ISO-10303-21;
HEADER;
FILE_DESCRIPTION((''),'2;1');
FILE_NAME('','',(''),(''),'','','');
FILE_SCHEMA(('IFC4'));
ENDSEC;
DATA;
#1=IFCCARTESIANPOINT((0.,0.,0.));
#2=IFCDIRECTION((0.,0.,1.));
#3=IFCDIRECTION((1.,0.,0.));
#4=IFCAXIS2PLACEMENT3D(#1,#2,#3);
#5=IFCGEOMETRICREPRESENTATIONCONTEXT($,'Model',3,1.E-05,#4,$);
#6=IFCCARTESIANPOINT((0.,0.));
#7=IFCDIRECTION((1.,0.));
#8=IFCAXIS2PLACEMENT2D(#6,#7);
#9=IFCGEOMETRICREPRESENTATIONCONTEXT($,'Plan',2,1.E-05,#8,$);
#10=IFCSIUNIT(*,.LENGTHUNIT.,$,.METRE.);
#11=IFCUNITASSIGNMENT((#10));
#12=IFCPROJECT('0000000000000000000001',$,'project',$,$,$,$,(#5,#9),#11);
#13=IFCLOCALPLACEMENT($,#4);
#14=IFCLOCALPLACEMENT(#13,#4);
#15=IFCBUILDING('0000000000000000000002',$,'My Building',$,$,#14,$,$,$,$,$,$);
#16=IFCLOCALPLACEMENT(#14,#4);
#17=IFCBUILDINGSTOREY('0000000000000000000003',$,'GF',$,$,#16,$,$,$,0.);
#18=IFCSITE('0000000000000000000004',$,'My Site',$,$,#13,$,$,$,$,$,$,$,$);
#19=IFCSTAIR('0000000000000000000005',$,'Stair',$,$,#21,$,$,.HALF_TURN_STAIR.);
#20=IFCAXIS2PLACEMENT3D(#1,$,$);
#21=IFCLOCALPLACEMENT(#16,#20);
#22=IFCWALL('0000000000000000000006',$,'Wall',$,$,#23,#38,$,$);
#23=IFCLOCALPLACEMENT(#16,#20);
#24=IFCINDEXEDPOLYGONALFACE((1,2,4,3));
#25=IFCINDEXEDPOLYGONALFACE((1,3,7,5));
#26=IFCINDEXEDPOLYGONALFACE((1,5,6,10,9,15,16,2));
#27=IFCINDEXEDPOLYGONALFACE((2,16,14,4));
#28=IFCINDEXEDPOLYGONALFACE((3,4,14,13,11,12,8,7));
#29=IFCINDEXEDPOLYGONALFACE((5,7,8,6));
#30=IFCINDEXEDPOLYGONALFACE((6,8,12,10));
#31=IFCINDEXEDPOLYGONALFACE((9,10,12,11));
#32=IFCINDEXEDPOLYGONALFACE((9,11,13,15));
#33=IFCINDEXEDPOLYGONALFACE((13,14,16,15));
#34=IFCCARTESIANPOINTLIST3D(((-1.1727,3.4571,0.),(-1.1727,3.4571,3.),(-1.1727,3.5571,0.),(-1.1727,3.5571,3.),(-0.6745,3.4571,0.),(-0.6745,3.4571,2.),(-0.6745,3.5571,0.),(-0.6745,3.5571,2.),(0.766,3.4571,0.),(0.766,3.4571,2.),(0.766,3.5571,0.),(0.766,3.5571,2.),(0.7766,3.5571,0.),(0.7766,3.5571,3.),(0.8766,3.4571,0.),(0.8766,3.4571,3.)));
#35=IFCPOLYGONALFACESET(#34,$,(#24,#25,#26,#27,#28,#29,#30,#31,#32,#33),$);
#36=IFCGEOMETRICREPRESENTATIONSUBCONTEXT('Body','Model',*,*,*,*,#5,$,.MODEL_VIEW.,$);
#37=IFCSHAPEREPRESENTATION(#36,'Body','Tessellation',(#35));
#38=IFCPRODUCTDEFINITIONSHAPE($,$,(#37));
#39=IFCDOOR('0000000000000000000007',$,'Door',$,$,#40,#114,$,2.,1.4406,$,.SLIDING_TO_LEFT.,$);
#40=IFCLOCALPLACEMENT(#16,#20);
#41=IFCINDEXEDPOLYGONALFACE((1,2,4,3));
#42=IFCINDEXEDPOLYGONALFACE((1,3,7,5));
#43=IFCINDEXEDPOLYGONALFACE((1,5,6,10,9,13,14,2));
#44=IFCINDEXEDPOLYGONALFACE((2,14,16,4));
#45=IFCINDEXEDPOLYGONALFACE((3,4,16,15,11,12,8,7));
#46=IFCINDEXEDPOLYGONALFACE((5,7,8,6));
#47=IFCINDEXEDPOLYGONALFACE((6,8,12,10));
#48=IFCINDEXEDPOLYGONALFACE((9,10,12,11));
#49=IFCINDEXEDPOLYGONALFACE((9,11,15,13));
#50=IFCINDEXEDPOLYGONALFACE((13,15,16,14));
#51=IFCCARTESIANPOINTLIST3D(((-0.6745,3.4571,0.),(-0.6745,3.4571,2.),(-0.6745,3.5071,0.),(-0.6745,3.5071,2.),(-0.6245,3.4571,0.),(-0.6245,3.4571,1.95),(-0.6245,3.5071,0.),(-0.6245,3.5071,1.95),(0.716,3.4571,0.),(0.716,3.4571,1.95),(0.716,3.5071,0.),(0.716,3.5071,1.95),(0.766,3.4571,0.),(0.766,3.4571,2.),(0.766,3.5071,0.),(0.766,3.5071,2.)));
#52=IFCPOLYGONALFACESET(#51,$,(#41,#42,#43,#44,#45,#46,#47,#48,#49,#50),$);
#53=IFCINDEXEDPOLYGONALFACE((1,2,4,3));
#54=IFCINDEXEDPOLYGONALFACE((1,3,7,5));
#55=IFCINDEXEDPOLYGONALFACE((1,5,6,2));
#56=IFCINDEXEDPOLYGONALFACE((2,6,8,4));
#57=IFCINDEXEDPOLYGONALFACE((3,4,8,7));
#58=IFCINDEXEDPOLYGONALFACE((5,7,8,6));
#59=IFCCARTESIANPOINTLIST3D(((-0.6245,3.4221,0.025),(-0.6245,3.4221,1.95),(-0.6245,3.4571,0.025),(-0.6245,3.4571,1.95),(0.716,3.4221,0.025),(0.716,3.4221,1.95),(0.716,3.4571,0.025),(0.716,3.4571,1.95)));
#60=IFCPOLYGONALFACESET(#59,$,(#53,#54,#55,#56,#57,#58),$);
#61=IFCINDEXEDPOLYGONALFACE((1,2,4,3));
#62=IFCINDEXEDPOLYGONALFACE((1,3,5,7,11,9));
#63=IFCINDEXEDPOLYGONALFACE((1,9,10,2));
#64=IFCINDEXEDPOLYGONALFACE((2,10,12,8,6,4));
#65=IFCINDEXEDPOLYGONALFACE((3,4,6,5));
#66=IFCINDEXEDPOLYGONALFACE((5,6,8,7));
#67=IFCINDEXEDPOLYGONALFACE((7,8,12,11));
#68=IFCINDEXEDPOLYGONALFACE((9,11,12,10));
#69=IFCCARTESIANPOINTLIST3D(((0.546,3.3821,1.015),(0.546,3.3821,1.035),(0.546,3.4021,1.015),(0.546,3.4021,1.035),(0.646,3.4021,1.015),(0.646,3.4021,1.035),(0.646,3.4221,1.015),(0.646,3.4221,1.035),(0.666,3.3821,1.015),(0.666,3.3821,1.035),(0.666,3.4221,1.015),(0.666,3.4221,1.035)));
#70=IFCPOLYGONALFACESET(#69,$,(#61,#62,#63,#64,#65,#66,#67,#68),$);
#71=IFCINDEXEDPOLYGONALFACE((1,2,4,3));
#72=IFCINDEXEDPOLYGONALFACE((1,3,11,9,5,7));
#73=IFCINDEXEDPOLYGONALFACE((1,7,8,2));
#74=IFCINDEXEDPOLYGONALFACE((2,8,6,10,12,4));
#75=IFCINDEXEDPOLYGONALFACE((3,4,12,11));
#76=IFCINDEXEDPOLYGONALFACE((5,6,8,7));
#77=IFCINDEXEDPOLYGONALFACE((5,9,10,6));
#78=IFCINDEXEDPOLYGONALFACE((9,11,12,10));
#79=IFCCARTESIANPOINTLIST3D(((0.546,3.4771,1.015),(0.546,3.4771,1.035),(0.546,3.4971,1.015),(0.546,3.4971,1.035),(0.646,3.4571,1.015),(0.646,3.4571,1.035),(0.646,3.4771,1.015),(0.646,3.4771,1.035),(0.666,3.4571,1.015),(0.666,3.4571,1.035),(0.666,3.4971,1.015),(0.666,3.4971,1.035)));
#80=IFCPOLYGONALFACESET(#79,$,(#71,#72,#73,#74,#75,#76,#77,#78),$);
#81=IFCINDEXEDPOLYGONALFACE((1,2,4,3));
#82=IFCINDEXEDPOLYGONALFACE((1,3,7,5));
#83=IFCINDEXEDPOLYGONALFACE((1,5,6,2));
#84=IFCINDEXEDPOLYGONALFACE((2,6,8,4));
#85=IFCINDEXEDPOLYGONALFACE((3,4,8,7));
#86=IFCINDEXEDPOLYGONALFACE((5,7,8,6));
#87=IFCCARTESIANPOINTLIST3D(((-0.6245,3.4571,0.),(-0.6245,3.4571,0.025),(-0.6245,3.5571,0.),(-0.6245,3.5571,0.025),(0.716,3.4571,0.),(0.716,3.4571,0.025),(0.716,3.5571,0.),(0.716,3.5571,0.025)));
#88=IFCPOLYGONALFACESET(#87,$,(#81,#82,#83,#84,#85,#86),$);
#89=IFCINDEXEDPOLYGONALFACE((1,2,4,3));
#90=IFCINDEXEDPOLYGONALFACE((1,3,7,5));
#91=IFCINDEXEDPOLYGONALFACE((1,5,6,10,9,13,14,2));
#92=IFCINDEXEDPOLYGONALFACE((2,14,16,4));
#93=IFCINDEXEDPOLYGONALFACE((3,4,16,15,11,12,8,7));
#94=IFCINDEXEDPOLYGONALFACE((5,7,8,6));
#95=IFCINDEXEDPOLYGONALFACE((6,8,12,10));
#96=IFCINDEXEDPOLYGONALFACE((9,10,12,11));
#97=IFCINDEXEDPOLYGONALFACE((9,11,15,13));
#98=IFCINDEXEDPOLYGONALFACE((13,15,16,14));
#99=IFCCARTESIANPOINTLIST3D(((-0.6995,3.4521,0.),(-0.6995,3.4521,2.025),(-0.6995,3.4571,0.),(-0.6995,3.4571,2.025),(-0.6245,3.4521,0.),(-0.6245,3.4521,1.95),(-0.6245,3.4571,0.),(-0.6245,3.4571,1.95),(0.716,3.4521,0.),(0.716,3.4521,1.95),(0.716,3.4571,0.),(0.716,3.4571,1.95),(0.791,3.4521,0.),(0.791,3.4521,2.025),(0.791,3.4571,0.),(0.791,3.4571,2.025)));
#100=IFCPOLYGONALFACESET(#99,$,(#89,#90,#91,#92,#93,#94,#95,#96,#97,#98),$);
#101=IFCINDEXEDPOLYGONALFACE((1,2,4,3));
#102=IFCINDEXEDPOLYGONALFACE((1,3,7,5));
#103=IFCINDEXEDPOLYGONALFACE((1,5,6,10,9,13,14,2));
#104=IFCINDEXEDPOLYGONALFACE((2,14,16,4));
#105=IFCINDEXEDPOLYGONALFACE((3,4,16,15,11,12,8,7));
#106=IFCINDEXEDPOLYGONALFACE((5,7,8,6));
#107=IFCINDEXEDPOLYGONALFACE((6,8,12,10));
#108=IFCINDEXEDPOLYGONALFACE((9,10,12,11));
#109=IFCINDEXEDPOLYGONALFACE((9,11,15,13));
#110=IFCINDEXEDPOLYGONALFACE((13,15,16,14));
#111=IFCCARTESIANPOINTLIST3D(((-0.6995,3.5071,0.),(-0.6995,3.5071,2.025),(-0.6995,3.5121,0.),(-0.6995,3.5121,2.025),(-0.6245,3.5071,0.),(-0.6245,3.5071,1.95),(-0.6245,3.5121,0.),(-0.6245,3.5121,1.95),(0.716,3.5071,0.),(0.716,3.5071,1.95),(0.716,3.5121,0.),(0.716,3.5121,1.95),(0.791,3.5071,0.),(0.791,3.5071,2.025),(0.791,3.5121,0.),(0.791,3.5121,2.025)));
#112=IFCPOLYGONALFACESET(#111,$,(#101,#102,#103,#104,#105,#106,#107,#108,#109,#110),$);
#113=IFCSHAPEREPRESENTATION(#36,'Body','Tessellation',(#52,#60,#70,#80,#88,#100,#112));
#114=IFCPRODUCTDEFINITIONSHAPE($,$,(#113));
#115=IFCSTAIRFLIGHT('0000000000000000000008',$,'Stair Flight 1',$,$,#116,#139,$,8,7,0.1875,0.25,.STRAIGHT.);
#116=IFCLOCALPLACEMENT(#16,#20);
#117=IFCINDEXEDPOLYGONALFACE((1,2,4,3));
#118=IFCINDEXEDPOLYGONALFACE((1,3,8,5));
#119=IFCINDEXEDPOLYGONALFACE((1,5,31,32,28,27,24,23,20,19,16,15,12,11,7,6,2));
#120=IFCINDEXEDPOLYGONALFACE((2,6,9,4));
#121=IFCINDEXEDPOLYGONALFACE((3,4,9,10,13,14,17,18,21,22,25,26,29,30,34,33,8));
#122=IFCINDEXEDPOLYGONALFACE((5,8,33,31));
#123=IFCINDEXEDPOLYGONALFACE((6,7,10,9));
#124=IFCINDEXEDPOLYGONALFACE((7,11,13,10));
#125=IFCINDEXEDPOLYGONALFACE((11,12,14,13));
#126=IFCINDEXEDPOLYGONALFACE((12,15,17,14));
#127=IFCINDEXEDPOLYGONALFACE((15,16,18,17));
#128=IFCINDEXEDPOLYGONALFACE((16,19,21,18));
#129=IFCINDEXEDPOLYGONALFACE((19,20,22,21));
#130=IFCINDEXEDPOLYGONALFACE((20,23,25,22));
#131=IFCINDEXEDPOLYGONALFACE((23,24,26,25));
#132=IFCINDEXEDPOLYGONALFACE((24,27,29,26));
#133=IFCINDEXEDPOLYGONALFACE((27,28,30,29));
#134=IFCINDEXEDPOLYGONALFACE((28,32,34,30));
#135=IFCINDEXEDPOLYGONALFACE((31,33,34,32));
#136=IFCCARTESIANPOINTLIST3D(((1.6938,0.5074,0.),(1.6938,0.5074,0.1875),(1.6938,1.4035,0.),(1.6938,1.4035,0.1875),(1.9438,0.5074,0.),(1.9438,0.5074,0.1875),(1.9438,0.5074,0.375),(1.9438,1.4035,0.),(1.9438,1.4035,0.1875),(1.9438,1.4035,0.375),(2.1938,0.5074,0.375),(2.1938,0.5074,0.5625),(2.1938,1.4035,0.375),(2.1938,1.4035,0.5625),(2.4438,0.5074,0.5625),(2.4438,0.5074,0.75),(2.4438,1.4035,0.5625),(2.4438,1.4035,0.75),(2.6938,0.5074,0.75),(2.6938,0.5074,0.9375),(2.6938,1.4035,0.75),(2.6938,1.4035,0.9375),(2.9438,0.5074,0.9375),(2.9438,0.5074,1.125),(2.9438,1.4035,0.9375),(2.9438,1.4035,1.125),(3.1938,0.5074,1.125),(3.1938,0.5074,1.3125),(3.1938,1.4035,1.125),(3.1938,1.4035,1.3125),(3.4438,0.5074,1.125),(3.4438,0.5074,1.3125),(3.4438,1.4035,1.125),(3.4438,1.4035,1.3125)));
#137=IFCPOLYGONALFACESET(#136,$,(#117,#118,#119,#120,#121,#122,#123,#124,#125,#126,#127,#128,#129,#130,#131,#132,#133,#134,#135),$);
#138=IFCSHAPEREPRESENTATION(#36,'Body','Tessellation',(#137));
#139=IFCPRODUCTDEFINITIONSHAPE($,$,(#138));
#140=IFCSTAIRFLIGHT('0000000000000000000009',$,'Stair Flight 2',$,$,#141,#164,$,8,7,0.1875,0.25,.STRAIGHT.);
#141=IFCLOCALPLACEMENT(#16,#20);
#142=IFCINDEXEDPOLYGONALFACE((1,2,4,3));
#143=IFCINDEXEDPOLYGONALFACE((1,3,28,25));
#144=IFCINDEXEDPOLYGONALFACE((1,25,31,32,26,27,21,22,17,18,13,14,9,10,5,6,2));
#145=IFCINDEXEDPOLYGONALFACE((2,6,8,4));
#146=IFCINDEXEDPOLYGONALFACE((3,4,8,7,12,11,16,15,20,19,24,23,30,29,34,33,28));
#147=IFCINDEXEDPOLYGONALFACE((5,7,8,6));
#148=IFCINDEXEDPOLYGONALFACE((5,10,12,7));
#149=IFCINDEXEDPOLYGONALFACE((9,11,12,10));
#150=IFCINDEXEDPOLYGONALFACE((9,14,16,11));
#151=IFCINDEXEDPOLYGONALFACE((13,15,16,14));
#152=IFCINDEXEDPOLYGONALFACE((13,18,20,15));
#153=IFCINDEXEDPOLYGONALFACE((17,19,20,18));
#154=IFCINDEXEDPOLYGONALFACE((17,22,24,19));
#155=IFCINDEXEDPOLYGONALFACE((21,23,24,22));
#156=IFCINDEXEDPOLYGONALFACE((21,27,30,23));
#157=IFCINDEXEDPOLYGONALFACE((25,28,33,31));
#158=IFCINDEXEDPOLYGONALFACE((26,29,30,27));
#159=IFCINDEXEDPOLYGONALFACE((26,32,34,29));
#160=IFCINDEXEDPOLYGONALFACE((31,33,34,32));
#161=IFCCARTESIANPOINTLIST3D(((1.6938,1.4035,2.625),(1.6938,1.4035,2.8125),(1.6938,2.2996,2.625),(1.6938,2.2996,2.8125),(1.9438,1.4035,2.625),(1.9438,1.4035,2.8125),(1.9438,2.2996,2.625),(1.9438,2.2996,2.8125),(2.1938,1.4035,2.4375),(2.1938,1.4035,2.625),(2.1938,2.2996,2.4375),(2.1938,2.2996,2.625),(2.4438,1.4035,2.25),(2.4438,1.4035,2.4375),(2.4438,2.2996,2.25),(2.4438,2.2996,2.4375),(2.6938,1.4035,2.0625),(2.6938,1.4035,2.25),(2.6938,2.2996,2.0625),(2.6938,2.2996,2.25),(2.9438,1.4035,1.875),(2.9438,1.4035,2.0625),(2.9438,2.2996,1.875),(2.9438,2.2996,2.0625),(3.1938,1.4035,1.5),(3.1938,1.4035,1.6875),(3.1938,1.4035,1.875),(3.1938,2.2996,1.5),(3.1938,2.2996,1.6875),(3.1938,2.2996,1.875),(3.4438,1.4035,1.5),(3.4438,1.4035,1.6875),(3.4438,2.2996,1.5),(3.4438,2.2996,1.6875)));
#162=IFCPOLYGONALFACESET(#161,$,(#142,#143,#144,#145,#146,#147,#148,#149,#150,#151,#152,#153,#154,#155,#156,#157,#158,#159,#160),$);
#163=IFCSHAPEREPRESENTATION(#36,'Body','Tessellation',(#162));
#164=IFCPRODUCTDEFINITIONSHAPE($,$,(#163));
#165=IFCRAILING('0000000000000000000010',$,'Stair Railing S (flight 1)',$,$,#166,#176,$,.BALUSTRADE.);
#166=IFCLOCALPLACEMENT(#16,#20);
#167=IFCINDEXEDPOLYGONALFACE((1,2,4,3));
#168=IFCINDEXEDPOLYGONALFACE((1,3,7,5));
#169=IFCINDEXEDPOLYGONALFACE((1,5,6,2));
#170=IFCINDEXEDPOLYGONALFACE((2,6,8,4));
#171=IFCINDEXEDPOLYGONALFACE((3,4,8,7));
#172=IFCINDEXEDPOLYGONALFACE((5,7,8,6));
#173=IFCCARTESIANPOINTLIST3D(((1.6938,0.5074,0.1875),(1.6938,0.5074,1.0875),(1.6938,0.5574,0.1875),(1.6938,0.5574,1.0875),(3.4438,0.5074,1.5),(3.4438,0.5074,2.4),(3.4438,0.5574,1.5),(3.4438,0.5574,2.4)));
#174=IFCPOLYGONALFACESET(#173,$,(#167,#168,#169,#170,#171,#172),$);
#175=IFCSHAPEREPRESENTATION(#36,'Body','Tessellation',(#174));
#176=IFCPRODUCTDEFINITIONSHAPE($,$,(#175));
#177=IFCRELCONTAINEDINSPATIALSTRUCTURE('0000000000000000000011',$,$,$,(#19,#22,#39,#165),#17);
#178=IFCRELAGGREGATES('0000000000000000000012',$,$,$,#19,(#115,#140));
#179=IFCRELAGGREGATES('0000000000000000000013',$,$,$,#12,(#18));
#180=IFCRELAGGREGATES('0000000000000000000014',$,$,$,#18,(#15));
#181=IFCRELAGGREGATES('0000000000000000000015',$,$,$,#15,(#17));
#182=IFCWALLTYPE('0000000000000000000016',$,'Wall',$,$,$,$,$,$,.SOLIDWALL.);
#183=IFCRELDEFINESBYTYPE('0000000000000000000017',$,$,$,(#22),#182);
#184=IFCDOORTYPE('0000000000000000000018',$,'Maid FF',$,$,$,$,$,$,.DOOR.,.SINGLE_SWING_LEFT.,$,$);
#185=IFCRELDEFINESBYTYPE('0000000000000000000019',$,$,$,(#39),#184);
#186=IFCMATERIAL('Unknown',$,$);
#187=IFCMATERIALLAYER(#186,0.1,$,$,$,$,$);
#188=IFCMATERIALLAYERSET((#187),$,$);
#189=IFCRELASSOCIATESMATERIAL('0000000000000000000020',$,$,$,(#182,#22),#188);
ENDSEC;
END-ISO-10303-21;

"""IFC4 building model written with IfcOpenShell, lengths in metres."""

from ifc_helpers import new_model, entity, si_unit, frame, origin_with_axes, origin_2d_with_axis, place, context, subcontext, project, spatial, polyline, line, indexed_curve, outline, extrude, shape, source, transform, mapped, material, layer, layer_set, layer_usage, type_object, type_shapes, element, fill, aggregate, save


model = new_model("IFC4")

# Units and contexts
model_context = context("Model", 3, precision=1e-05, world=origin_with_axes())
plan_context = context("Plan", 2, precision=1e-05, world=origin_2d_with_axis())
body_context_1 = subcontext(model_context, "Body", "Model", "MODEL_VIEW")
body_context_2 = subcontext(plan_context, "Body", "Plan", "PLAN_VIEW")
ifc_project = project(units=[si_unit("LENGTHUNIT", "METRE")], contexts=[model_context, plan_context])

# Site, building, storey
site_placement = place(None, origin_with_axes())
site = spatial("IfcSite", under=ifc_project, at=site_placement, Name="My Site")
building_placement = place(site_placement, origin_with_axes())
building = spatial("IfcBuilding", under=site, at=building_placement, Name="My Building")
storey_placement = place(building_placement, origin_with_axes())
storey = spatial("IfcBuildingStorey", under=building, at=storey_placement, Name="GF", Elevation=0.0)

# Shared definitions
ifc_material = material(Name="Unknown")

# Stair
stair_placement = place(storey_placement, origin_with_axes())
stair = element("IfcStair", 1, at=stair_placement, inside=storey, Name="Stair", PredefinedType="HALF_TURN_STAIR")

# Shared definitions
ifc_layer_1 = layer(ifc_material, 0.1)
ifc_layer_set_1 = layer_set([ifc_layer_1])
wall_type = type_object("IfcWallType", Name="Wall", PredefinedType="SOLIDWALL", material=ifc_layer_set_1)

# Wall, opening, door
ifc_layer_usage_1 = layer_usage(ifc_layer_set_1, "AXIS2", "POSITIVE", 0.0)
wall_1_placement = place(storey_placement, frame((0.7766, 3.5571, 0.0), z_axis=(0.0, 0.0, 1.0), x_axis=(-1.0, 0.0, 0.0)))
wall_1 = element("IfcWall", 2, at=wall_1_placement, inside=storey, type_object=wall_type, material=ifc_layer_usage_1, Name="Wall", context=body_context_1, shape_type="SweptSolid", body=[
    extrude(outline(indexed_curve([(0.0, 0.0), (-0.1, 0.1), (1.9493, 0.1), (1.9493, 0.0)], segments=[line(1, 2, 3, 4, 1)])), origin_with_axes(), (0.0, 0.0, 1.0), 3.0),
])
shared_shape_1 = source(origin_with_axes(), body_context_1, "Body", "SweptSolid", [
    extrude(outline(indexed_curve([(0.0, 0.0), (1.4406, 0.0), (1.4406, 2.0), (0.0, 2.0)], segments=[line(1, 2, 3, 4, 1)])), frame((0.0, -0.6, 0.0), z_axis=(0.0, -1.0, 0.0), x_axis=(1.0, 0.0, 0.0)), (0.0, 0.0, -1.0), 1.2),
])
opening_1_placement = place(wall_1_placement, frame((1.4511, 0.1, 0.0), z_axis=(0.0, 0.0, 1.0), x_axis=(-1.0, 0.000001, 0.0)))
opening_1 = element("IfcOpeningElement", 3, at=opening_1_placement, cuts=wall_1, PredefinedType="OPENING", context=body_context_1, shape_type="MappedRepresentation", body=[
    mapped(shared_shape_1, transform((0.0, 0.0, 0.0), x_axis=(1.0, 0.0, 0.0), y_axis=(0.0, 1.0, 0.0), z_axis=(0.0, 0.0, 1.0), scale=1.0)),
])
door_type_1 = type_object("IfcDoorType", Name="Maid FF", OperationType="SINGLE_SWING_LEFT", PredefinedType="DOOR")
shared_shape_2 = source(origin_with_axes(), body_context_1, "Body", "SweptSolid", [
    extrude(outline(indexed_curve([(0.0, 0.0), (0.0, 2.0), (1.4406, 2.0), (1.4406, 0.0), (1.3906, 0.0), (1.3906, 1.95), (0.05, 1.95), (0.05, 0.0)], segments=[line(1, 2, 3, 4, 5, 6, 7, 8, 1)])), frame((0.0, 0.0, 0.0), z_axis=(0.0, -1.0, 0.0), x_axis=(1.0, 0.0, 0.0)), (0.0, 0.0, -1.0), 0.05),
    extrude(outline(indexed_curve([(0.0, 0.0), (1.3406, 0.0), (1.3406, 0.035), (0.0, 0.035)], segments=[line(1, 2, 3, 4, 1)])), frame((0.05, -0.035, 0.025), z_axis=(0.0, 0.0, 1.0), x_axis=(1.0, 0.0, 0.0)), (0.0, 0.0, 1.0), 1.925),
    extrude(outline(indexed_curve([(0.0, 0.0), (0.0, -0.04), (-0.12, -0.04), (-0.12, -0.02), (-0.02, -0.02), (-0.02, 0.0)], segments=[line(1, 2, 3, 4, 5, 6, 1)])), frame((1.3406, -0.035, 1.015), z_axis=(0.0, 0.0, 1.0), x_axis=(1.0, 0.0, 0.0)), (0.0, 0.0, 1.0), 0.02),
    extrude(outline(indexed_curve([(0.0, 0.0), (0.0, 0.04), (-0.12, 0.04), (-0.12, 0.02), (-0.02, 0.02), (-0.02, 0.0)], segments=[line(1, 2, 3, 4, 5, 6, 1)])), frame((1.3406, 0.0, 1.015), z_axis=(0.0, 0.0, 1.0), x_axis=(1.0, 0.0, 0.0)), (0.0, 0.0, 1.0), 0.02),
    extrude(outline(indexed_curve([(0.0, 0.0), (1.3406, 0.0), (1.3406, 0.1), (0.0, 0.1)], segments=[line(1, 2, 3, 4, 1)])), frame((0.05, 0.0, 0.0), z_axis=(0.0, 0.0, 1.0), x_axis=(1.0, 0.0, 0.0)), (0.0, 0.0, 1.0), 0.025),
    extrude(outline(indexed_curve([(0.0, 0.0), (0.0, 2.025), (1.4906, 2.025), (1.4906, 0.0), (1.4156, 0.0), (1.4156, 1.95), (0.075, 1.95), (0.075, 0.0)], segments=[line(1, 2, 3, 4, 5, 6, 7, 8, 1)])), frame((-0.025, -0.005, 0.0), z_axis=(0.0, -1.0, 0.0), x_axis=(1.0, 0.0, 0.0)), (0.0, 0.0, -1.0), 0.005),
    extrude(outline(indexed_curve([(0.0, 0.0), (0.0, 2.025), (1.4906, 2.025), (1.4906, 0.0), (1.4156, 0.0), (1.4156, 1.95), (0.075, 1.95), (0.075, 0.0)], segments=[line(1, 2, 3, 4, 5, 6, 7, 8, 1)])), frame((-0.025, 0.05, 0.0), z_axis=(0.0, -1.0, 0.0), x_axis=(1.0, 0.0, 0.0)), (0.0, 0.0, -1.0), 0.005),
])
shared_shape_3 = source(origin_with_axes(), body_context_2, "Body", "Curve2D", [
    entity("IfcIndexedPolyCurve", entity("IfcCartesianPointList2D", [[0.0, 0.0], [0.05, 0.0], [0.05, 0.05], [0.0, 0.05]]), [entity("IfcLineIndex", [1, 2, 3, 4, 1])]),
    entity("IfcIndexedPolyCurve", entity("IfcCartesianPointList2D", [[1.4406, 0.0], [1.3906, 0.0], [1.3906, 0.05], [1.4406, 0.05]]), [entity("IfcLineIndex", [1, 2, 3, 4, 1])]),
    entity("IfcIndexedPolyCurve", entity("IfcCartesianPointList2D", [[-0.6203, -0.035], [0.7203, -0.035], [0.7203, 0.0], [-0.6203, 0.0]]), [entity("IfcLineIndex", [1, 2, 3, 4, 1])]),
])
type_shapes(door_type_1, [shared_shape_2, shared_shape_3])
door_1_placement = place(opening_1_placement, frame((0.0, 0.0, 0.0), z_axis=(0.0, 0.0, 1.0), x_axis=(1.0, 0.0, 0.0)))
door_1 = element("IfcDoor", 4, at=door_1_placement, inside=storey, type_object=door_type_1, Name="Door", OperationType="SLIDING_TO_LEFT", OverallHeight=2.0, OverallWidth=1.4406, shapes=[
    shape(body_context_1, "Body", "MappedRepresentation", [mapped(shared_shape_2, transform((0.0, 0.0, 0.0), x_axis=(1.0, 0.0, 0.0), y_axis=(0.0, 1.0, 0.0), z_axis=(0.0, 0.0, 1.0), scale=1.0))]),
    shape(body_context_2, "Body", "MappedRepresentation", [mapped(shared_shape_3, transform((0.0, 0.0, 0.0), x_axis=(1.0, 0.0, 0.0), y_axis=(0.0, 1.0, 0.0), z_axis=(0.0, 0.0, 1.0), scale=1.0))]),
])
fill(opening_1, door_1)

# Stair flights
stair_flight_1_placement = place(stair_placement, frame((1.6938, 1.4035, 0.0), z_axis=(0.0, -1.0, 0.0), x_axis=(1.0, 0.0, 0.0)))
stair_flight_1 = element("IfcStairFlight", 5, at=stair_flight_1_placement, Name="Stair Flight 1", NumberOfRisers=8, NumberOfTreads=7, PredefinedType="STRAIGHT", RiserHeight=0.1875, TreadLength=0.25, context=body_context_1, shape_type="SweptSolid", body=[
    extrude(outline(polyline([(0.25, 0.0), (0.0, 0.0), (0.0, 0.1875), (0.25, 0.1875), (0.25, 0.375), (0.5, 0.375), (0.5, 0.5625), (0.75, 0.5625), (0.75, 0.75), (1.0, 0.75), (1.0, 0.9375), (1.25, 0.9375), (1.25, 1.125), (1.5, 1.125), (1.5, 1.3125), (1.75, 1.3125), (1.75, 1.5), (1.75, 1.125), (0.25, 0.0)])), origin_with_axes(), (0.0, 0.0, 1.0), 0.8961),
])
stair_flight_2_placement = place(stair_placement, frame((3.4438, 1.4035, 1.5), z_axis=(0.0, 1.0, 0.0), x_axis=(-1.0, 0.0, 0.0)))
stair_flight_2 = element("IfcStairFlight", 6, at=stair_flight_2_placement, Name="Stair Flight 2", NumberOfRisers=8, NumberOfTreads=7, PredefinedType="STRAIGHT", RiserHeight=0.1875, TreadLength=0.25, context=body_context_1, shape_type="SweptSolid", body=[
    extrude(outline(polyline([(0.25, 0.0), (0.0, 0.0), (0.0, 0.1875), (0.25, 0.1875), (0.25, 0.375), (0.5, 0.375), (0.5, 0.5625), (0.75, 0.5625), (0.75, 0.75), (1.0, 0.75), (1.0, 0.9375), (1.25, 0.9375), (1.25, 1.125), (1.5, 1.125), (1.5, 1.3125), (1.75, 1.3125), (1.75, 1.5), (1.75, 1.125), (0.25, 0.0)])), origin_with_axes(), (0.0, 0.0, 1.0), 0.8961),
])
aggregate(stair, [stair_flight_1, stair_flight_2])

# Railing
for number, where, z_axis, x_axis, name in (
    (7, (1.6938, 0.5574, 0.0), (0.0, -1.0, 0.0), (1.0, 0.0, 0.0), "Stair Railing S (flight 1)"),
):
    element("IfcRailing", number, at=place(storey_placement, frame(where, z_axis=z_axis, x_axis=x_axis)), inside=storey, Name=name, PredefinedType="BALUSTRADE", context=body_context_1, shape_type="SweptSolid", body=[
        extrude(outline(polyline([(0.0, 0.1875), (1.75, 1.5), (1.75, 2.4), (0.0, 1.0875), (0.0, 0.1875)])), origin_with_axes(), (0.0, 0.0, 1.0), 0.05),
    ])

save(model, "model.ifc")
